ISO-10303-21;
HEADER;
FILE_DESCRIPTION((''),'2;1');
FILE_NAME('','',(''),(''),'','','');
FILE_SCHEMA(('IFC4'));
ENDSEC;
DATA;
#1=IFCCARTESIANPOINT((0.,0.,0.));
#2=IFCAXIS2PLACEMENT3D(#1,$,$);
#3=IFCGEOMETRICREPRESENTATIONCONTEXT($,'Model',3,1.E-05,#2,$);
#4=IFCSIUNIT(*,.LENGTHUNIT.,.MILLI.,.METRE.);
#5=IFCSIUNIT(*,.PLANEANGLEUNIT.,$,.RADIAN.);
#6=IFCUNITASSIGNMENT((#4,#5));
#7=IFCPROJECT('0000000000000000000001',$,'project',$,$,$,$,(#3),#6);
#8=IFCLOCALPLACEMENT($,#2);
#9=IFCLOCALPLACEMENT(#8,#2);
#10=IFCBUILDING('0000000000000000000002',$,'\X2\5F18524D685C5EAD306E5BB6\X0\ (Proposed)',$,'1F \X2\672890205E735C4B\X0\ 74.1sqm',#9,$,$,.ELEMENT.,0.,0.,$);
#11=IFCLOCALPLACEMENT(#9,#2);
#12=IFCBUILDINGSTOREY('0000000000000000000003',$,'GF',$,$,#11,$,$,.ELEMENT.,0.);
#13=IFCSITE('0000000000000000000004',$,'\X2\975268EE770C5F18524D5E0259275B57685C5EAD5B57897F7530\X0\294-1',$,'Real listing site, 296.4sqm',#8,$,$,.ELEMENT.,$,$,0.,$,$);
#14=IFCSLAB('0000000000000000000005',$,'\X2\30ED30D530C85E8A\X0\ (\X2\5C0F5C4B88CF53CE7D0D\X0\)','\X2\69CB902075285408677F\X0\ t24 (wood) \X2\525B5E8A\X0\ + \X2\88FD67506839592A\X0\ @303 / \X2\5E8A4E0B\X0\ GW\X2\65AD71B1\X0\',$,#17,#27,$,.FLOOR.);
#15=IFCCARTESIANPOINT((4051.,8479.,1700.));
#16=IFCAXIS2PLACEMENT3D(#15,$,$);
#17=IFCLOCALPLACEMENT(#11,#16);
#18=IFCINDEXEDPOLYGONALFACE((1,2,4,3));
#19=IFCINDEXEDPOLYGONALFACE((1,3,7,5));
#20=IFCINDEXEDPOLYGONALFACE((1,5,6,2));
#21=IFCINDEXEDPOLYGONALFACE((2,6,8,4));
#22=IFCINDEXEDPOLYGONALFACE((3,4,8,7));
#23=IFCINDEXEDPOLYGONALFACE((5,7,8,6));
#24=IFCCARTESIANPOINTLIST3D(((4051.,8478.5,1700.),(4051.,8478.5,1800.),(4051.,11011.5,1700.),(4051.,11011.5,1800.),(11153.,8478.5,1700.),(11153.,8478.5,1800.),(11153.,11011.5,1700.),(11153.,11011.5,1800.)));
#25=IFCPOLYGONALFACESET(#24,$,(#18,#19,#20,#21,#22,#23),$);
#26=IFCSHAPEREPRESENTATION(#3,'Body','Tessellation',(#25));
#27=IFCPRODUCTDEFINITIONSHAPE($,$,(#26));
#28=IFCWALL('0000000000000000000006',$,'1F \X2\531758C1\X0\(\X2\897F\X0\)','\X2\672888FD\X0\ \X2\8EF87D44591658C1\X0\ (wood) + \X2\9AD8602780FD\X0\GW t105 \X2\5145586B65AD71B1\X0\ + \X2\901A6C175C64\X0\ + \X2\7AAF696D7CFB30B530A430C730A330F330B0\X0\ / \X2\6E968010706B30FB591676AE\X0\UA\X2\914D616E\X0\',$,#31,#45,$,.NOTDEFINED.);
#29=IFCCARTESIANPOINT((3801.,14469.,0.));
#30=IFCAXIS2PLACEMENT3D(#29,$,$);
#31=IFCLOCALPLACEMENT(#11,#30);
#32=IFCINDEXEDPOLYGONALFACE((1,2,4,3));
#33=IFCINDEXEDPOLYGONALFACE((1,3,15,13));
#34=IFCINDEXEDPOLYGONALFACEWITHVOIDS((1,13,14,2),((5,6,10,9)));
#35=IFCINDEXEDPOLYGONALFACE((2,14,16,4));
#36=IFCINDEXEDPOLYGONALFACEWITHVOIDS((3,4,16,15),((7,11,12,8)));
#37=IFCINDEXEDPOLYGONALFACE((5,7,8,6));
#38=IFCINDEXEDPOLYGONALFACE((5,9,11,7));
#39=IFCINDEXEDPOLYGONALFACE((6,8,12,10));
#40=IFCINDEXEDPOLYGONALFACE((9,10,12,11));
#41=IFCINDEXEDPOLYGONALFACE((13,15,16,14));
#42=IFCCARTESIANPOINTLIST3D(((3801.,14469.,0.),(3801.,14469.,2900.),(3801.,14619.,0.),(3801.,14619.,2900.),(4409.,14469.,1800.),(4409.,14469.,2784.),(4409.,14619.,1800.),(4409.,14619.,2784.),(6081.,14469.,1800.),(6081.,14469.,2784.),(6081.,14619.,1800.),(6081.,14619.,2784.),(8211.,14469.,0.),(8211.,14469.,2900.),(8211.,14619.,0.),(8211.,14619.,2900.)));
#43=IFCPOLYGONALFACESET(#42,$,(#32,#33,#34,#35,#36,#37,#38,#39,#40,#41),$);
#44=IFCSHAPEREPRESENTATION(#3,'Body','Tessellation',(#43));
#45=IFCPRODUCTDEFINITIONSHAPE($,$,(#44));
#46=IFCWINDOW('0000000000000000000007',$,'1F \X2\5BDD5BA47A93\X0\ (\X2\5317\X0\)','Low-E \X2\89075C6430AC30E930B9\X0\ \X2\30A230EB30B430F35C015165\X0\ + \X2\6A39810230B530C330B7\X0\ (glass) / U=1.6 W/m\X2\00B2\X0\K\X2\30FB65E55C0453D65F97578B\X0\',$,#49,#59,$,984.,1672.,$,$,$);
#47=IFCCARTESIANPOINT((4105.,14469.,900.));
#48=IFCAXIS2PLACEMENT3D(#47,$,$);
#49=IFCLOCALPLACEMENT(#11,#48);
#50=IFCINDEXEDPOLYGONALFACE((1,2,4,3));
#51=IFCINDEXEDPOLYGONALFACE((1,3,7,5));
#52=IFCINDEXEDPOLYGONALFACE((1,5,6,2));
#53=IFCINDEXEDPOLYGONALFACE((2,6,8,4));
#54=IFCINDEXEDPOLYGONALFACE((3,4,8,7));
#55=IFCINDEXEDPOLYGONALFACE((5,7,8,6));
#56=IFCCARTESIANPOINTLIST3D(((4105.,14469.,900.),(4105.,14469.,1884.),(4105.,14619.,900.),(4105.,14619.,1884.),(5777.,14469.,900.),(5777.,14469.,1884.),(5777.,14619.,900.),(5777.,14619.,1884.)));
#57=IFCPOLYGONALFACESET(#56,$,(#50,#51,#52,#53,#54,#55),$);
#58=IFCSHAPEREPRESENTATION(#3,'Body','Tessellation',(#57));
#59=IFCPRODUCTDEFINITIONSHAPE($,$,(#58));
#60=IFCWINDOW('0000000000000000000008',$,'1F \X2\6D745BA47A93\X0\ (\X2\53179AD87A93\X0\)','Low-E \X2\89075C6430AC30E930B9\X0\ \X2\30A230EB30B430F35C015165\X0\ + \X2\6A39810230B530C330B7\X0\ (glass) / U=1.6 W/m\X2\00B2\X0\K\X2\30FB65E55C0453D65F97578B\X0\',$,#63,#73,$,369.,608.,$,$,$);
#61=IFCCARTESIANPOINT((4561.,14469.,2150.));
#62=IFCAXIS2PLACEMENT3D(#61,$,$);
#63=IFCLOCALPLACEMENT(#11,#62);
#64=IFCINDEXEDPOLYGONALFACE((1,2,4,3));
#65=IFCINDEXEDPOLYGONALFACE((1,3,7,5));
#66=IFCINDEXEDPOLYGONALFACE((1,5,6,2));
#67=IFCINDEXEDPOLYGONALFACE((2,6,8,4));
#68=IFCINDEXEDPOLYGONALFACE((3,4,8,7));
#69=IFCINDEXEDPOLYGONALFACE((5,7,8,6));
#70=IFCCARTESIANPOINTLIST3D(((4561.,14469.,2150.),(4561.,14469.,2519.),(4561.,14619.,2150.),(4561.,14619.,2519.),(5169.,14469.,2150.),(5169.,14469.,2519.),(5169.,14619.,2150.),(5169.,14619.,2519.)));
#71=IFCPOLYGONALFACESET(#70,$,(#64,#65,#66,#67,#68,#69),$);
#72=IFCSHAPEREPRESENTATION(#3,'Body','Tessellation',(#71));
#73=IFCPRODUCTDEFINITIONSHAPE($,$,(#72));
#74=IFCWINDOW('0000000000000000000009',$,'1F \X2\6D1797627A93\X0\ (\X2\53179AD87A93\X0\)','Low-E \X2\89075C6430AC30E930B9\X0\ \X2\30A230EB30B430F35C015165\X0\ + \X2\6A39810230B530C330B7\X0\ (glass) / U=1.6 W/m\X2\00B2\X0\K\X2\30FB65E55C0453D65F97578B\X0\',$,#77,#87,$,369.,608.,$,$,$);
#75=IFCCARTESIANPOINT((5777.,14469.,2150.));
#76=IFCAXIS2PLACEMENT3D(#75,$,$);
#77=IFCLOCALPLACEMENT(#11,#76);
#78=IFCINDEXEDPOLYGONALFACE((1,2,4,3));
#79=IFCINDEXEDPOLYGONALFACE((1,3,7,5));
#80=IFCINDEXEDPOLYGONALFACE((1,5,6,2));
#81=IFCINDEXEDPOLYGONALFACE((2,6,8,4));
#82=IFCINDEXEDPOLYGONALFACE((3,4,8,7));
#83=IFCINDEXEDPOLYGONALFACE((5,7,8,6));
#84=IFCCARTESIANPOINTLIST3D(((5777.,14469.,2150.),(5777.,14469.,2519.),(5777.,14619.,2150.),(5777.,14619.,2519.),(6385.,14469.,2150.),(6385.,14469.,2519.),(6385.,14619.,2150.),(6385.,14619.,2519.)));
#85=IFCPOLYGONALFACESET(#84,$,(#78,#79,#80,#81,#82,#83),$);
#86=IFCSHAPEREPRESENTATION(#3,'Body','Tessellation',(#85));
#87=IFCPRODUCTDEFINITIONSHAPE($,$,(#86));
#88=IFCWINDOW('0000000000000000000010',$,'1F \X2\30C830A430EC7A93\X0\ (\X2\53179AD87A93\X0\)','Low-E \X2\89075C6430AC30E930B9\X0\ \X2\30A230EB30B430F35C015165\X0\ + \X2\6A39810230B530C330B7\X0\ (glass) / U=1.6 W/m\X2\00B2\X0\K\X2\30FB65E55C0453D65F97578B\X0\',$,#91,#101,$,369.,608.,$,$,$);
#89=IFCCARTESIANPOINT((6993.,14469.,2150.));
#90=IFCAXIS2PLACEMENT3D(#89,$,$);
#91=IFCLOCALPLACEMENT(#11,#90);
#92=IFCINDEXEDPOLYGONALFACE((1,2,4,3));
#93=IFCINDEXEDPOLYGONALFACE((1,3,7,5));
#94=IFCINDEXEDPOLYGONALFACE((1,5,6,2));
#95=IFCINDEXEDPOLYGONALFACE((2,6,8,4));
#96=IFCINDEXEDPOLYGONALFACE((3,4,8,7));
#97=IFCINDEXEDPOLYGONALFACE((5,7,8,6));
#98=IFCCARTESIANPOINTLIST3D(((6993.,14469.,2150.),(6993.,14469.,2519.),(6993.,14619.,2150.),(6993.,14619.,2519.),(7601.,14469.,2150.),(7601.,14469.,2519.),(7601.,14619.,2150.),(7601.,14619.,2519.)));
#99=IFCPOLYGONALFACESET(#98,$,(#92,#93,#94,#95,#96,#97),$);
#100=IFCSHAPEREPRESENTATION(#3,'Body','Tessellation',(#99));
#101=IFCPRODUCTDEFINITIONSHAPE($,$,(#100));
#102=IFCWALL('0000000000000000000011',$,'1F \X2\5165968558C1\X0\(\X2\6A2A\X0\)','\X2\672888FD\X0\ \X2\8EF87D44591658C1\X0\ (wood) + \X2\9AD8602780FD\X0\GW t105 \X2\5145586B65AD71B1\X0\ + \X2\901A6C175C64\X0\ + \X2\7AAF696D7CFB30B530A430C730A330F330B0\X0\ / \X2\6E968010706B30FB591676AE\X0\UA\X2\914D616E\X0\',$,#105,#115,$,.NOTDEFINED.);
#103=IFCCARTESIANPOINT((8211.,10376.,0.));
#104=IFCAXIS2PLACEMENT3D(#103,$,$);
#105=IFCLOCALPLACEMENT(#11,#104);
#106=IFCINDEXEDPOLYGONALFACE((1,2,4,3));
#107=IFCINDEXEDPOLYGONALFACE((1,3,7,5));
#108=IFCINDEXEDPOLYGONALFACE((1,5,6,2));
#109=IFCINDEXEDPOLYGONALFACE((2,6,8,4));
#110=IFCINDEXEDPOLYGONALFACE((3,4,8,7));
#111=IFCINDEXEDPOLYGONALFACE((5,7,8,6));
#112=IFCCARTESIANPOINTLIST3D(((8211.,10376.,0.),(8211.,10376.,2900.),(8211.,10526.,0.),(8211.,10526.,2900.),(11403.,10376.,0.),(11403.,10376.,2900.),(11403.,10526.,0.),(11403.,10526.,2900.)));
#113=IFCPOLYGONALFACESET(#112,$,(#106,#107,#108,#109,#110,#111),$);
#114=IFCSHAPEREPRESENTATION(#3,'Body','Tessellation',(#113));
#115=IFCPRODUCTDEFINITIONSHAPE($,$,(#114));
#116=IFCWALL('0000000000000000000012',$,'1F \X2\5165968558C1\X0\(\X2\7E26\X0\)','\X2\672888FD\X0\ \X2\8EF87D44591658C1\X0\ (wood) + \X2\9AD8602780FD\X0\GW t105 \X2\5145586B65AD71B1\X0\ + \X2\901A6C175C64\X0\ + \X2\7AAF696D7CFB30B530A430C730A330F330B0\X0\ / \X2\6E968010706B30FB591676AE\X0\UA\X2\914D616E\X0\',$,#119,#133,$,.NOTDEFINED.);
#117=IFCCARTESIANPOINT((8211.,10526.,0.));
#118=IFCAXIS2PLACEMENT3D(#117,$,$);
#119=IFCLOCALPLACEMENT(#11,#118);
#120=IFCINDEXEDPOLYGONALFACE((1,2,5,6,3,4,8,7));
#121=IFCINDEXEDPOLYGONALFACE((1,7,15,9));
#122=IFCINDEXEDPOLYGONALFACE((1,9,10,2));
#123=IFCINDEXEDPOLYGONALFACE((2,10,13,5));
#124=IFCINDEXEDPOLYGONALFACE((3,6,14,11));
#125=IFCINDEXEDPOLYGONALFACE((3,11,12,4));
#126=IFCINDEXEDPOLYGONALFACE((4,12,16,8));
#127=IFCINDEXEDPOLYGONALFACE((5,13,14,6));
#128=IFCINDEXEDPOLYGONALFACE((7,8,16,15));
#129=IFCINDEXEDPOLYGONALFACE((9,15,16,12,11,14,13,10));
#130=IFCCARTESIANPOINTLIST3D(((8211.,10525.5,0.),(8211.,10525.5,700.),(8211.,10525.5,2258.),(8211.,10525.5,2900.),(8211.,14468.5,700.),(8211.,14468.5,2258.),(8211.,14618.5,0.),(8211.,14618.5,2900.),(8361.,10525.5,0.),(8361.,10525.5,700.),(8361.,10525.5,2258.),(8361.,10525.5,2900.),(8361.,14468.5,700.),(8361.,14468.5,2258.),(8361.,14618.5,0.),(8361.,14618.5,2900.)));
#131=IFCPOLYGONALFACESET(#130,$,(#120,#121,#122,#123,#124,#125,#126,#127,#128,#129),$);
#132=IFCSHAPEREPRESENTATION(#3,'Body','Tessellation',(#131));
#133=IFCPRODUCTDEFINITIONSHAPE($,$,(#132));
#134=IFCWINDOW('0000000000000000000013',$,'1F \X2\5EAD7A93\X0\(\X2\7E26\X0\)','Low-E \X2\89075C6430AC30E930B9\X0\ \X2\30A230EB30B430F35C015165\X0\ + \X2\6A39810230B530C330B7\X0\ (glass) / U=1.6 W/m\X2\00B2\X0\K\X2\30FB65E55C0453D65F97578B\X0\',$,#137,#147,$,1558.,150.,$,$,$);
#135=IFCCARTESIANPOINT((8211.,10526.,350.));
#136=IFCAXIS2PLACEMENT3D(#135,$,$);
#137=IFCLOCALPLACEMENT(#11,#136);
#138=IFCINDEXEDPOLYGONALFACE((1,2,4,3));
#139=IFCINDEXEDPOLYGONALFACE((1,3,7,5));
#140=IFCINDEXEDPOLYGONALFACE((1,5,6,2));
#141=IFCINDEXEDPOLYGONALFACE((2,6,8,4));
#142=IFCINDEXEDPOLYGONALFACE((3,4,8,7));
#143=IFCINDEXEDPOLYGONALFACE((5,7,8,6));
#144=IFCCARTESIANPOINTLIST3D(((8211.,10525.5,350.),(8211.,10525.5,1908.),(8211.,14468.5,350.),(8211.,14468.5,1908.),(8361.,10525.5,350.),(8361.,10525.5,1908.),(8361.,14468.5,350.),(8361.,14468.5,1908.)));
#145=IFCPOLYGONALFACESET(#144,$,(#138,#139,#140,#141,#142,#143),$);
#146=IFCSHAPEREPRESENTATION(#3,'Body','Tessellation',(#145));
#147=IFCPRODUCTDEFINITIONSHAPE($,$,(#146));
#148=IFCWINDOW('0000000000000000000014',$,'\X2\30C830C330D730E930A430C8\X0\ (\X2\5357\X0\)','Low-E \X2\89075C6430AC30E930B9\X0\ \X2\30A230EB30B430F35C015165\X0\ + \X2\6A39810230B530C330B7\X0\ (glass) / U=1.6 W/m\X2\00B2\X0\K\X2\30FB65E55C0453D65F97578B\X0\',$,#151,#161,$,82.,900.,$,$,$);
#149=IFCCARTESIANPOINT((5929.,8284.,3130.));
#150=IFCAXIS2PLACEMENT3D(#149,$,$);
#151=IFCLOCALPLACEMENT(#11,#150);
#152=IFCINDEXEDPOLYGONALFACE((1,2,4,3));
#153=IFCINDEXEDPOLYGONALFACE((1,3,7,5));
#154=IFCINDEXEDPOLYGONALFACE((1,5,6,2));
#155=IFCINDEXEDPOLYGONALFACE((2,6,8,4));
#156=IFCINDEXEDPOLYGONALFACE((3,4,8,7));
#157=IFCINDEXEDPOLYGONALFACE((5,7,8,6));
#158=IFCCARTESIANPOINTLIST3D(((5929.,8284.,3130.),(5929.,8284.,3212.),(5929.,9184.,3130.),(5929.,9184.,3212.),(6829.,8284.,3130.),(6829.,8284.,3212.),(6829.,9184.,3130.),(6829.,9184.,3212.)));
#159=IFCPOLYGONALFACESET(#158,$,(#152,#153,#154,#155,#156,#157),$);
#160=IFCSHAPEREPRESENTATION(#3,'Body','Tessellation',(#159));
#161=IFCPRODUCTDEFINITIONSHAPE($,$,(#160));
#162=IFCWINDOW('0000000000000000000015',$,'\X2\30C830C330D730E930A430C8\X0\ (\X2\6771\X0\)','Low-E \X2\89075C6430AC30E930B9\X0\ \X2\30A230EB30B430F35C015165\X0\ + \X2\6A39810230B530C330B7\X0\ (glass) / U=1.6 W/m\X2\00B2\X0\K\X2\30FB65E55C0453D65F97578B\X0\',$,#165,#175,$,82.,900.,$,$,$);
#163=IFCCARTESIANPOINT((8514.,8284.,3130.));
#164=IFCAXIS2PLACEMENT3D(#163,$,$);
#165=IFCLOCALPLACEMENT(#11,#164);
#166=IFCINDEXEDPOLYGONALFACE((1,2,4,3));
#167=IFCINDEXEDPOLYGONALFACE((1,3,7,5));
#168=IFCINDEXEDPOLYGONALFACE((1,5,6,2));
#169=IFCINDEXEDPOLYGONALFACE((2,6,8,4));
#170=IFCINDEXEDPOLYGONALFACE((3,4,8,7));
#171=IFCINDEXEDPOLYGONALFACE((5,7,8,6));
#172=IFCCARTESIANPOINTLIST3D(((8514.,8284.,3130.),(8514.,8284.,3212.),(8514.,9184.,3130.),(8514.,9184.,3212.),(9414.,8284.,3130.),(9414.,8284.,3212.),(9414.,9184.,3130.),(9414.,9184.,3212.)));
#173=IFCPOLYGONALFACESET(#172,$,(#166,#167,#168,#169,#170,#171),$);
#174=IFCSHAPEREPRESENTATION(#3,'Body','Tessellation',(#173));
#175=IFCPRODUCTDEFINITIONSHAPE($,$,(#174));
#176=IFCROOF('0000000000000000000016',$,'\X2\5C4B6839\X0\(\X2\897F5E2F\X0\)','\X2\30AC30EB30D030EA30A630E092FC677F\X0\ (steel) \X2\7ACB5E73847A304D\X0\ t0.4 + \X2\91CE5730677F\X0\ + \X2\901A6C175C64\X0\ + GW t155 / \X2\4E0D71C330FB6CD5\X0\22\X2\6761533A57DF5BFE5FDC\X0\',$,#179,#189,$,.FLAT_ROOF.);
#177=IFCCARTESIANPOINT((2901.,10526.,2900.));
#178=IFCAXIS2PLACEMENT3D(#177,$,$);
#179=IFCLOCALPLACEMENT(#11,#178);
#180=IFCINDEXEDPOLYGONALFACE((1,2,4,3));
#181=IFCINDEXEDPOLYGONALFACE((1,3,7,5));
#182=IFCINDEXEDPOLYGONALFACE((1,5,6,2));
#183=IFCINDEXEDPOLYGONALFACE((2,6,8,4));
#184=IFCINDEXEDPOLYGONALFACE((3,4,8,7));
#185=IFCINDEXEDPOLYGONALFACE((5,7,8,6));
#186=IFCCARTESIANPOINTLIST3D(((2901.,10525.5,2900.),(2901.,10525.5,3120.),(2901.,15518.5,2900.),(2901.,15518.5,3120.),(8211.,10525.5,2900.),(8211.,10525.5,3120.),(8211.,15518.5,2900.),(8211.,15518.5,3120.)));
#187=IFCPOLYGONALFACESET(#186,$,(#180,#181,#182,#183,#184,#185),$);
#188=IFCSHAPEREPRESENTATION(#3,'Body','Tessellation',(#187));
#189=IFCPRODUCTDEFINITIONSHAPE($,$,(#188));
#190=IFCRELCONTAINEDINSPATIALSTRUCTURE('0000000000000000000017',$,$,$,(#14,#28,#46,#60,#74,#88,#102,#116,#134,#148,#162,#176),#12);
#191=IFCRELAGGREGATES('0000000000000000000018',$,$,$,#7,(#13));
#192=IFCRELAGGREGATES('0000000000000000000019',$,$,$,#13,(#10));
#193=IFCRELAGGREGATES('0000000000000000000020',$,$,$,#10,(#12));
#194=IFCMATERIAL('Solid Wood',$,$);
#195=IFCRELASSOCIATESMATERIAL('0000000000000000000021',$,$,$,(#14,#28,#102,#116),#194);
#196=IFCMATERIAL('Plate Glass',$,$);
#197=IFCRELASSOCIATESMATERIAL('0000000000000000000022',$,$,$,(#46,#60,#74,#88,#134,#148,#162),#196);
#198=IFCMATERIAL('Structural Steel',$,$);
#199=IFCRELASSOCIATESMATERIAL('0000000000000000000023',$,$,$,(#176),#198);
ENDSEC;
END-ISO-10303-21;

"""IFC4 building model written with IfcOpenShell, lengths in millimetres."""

from ifc_helpers import new_model, si_unit, frame, frame_2d, origin, place, context, project, spatial, rectangle, extrude, material, element, fill, save


model = new_model("IFC4")

# Units and contexts
model_context = context("Model", 3, precision=1e-05, world=origin())
ifc_project = project(units=[si_unit("LENGTHUNIT", "METRE", prefix="MILLI"), si_unit("PLANEANGLEUNIT", "RADIAN")], contexts=[model_context])

# Site, building, storey
site_placement = place(None, origin())
site = spatial("IfcSite", under=ifc_project, at=site_placement, Name="青森県弘前市大字桜庭字西田294-1", ObjectType="Real listing site, 296.4sqm", CompositionType="ELEMENT", RefElevation=0.0)
building_placement = place(site_placement, origin())
building = spatial("IfcBuilding", under=site, at=building_placement, Name="弘前桜庭の家 (Proposed)", ObjectType="1F 木造平屋 74.1sqm", CompositionType="ELEMENT", ElevationOfRefHeight=0.0, ElevationOfTerrain=0.0)
storey_placement = place(building_placement, origin())
storey = spatial("IfcBuildingStorey", under=building, at=storey_placement, Name="GF", CompositionType="ELEMENT", Elevation=0.0)

# Slab
ifc_material_1 = material(Name="Solid Wood")
slab_1_placement = place(storey_placement, frame((4051.0, 8479.0, 1700.0)))
element("IfcSlab", 1, at=slab_1_placement, inside=storey, material=ifc_material_1, Name="ロフト床 (小屋裏収納)", Description="構造用合板 t24 (wood) 剛床 + 製材根太 @303 / 床下 GW断熱", PredefinedType="FLOOR", context=model_context, shape_type="SweptSolid", body=[
    extrude(rectangle(XDim=7102.0, YDim=2533.0, at=frame_2d((3551.0, 1266.0))), frame((4051.0, 8479.0, 1700.0)), (0.0, 0.0, 1.0), 100.0),
])

# Wall, openings, windows
wall_1_placement = place(storey_placement, frame((3801.0, 14469.0, 0.0)))
wall_1 = element("IfcWall", 2, at=wall_1_placement, inside=storey, material=ifc_material_1, Name="1F 北壁(西)", Description="木製 軸組外壁 (wood) + 高性能GW t105 充填断熱 + 通気層 + 窯業系サイディング / 準耐火・外皮UA配慮", PredefinedType="NOTDEFINED", context=model_context, shape_type="SweptSolid", body=[
    extrude(rectangle(XDim=4410.0, YDim=150.0, at=frame_2d((2205.0, 75.0))), frame((3801.0, 14469.0, 0.0)), (0.0, 0.0, 1.0), 2900.0),
])
opening_1_placement = place(storey_placement, frame((4105.0, 14469.0, 900.0)))
opening_1 = element("IfcOpeningElement", 3, at=opening_1_placement, cuts=wall_1, PredefinedType="NOTDEFINED", context=model_context, shape_type="SweptSolid", body=[
    extrude(rectangle(XDim=1672.0, YDim=150.0, at=frame_2d((836.0, 75.0))), frame((4105.0, 14469.0, 900.0)), (0.0, 0.0, 1.0), 984.0),
])
opening_2_placement = place(storey_placement, frame((4561.0, 14469.0, 2150.0)))
opening_2 = element("IfcOpeningElement", 4, at=opening_2_placement, cuts=wall_1, PredefinedType="NOTDEFINED", context=model_context, shape_type="SweptSolid", body=[
    extrude(rectangle(XDim=608.0, YDim=150.0, at=frame_2d((304.0, 75.0))), frame((4561.0, 14469.0, 2150.0)), (0.0, 0.0, 1.0), 369.0),
])
opening_3_placement = place(storey_placement, frame((5777.0, 14469.0, 2150.0)))
opening_3 = element("IfcOpeningElement", 5, at=opening_3_placement, cuts=wall_1, PredefinedType="NOTDEFINED", context=model_context, shape_type="SweptSolid", body=[
    extrude(rectangle(XDim=608.0, YDim=150.0, at=frame_2d((304.0, 75.0))), frame((5777.0, 14469.0, 2150.0)), (0.0, 0.0, 1.0), 369.0),
])
opening_4_placement = place(storey_placement, frame((6993.0, 14469.0, 2150.0)))
opening_4 = element("IfcOpeningElement", 6, at=opening_4_placement, cuts=wall_1, PredefinedType="NOTDEFINED", context=model_context, shape_type="SweptSolid", body=[
    extrude(rectangle(XDim=608.0, YDim=150.0, at=frame_2d((304.0, 75.0))), frame((6993.0, 14469.0, 2150.0)), (0.0, 0.0, 1.0), 369.0),
])
ifc_material_2 = material(Name="Plate Glass")
window_1_placement = place(storey_placement, frame((4105.0, 14469.0, 900.0)))
window_1 = element("IfcWindow", 7, at=window_1_placement, inside=storey, material=ifc_material_2, Name="1F 寝室窓 (北)", Description="Low-E 複層ガラス アルゴン封入 + 樹脂サッシ (glass) / U=1.6 W/m²K・日射取得型", OverallHeight=984.0, OverallWidth=1672.0, context=model_context, shape_type="SweptSolid", body=[
    extrude(rectangle(XDim=1672.0, YDim=150.0, at=frame_2d((836.0, 75.0))), frame((4105.0, 14469.0, 900.0)), (0.0, 0.0, 1.0), 984.0),
])
fill(opening_1, window_1)
window_2_placement = place(storey_placement, frame((4561.0, 14469.0, 2150.0)))
window_2 = element("IfcWindow", 8, at=window_2_placement, inside=storey, material=ifc_material_2, Name="1F 浴室窓 (北高窓)", Description="Low-E 複層ガラス アルゴン封入 + 樹脂サッシ (glass) / U=1.6 W/m²K・日射取得型", OverallHeight=369.0, OverallWidth=608.0, context=model_context, shape_type="SweptSolid", body=[
    extrude(rectangle(XDim=608.0, YDim=150.0, at=frame_2d((304.0, 75.0))), frame((4561.0, 14469.0, 2150.0)), (0.0, 0.0, 1.0), 369.0),
])
fill(opening_2, window_2)
window_3_placement = place(storey_placement, frame((5777.0, 14469.0, 2150.0)))
window_3 = element("IfcWindow", 9, at=window_3_placement, inside=storey, material=ifc_material_2, Name="1F 洗面窓 (北高窓)", Description="Low-E 複層ガラス アルゴン封入 + 樹脂サッシ (glass) / U=1.6 W/m²K・日射取得型", OverallHeight=369.0, OverallWidth=608.0, context=model_context, shape_type="SweptSolid", body=[
    extrude(rectangle(XDim=608.0, YDim=150.0, at=frame_2d((304.0, 75.0))), frame((5777.0, 14469.0, 2150.0)), (0.0, 0.0, 1.0), 369.0),
])
fill(opening_3, window_3)
window_4_placement = place(storey_placement, frame((6993.0, 14469.0, 2150.0)))
window_4 = element("IfcWindow", 10, at=window_4_placement, inside=storey, material=ifc_material_2, Name="1F トイレ窓 (北高窓)", Description="Low-E 複層ガラス アルゴン封入 + 樹脂サッシ (glass) / U=1.6 W/m²K・日射取得型", OverallHeight=369.0, OverallWidth=608.0, context=model_context, shape_type="SweptSolid", body=[
    extrude(rectangle(XDim=608.0, YDim=150.0, at=frame_2d((304.0, 75.0))), frame((6993.0, 14469.0, 2150.0)), (0.0, 0.0, 1.0), 369.0),
])
fill(opening_4, window_4)

# Wall
wall_2_placement = place(storey_placement, frame((8211.0, 10376.0, 0.0)))
element("IfcWall", 11, at=wall_2_placement, inside=storey, material=ifc_material_1, Name="1F 入隅壁(横)", Description="木製 軸組外壁 (wood) + 高性能GW t105 充填断熱 + 通気層 + 窯業系サイディング / 準耐火・外皮UA配慮", PredefinedType="NOTDEFINED", context=model_context, shape_type="SweptSolid", body=[
    extrude(rectangle(XDim=3192.0, YDim=150.0, at=frame_2d((1596.0, 75.0))), frame((8211.0, 10376.0, 0.0)), (0.0, 0.0, 1.0), 2900.0),
])

# Wall, opening, window
wall_3_placement = place(storey_placement, frame((8211.0, 10526.0, 0.0)))
wall_3 = element("IfcWall", 12, at=wall_3_placement, inside=storey, material=ifc_material_1, Name="1F 入隅壁(縦)", Description="木製 軸組外壁 (wood) + 高性能GW t105 充填断熱 + 通気層 + 窯業系サイディング / 準耐火・外皮UA配慮", PredefinedType="NOTDEFINED", context=model_context, shape_type="SweptSolid", body=[
    extrude(rectangle(XDim=150.0, YDim=4093.0, at=frame_2d((75.0, 2046.0))), frame((8211.0, 10526.0, 0.0)), (0.0, 0.0, 1.0), 2900.0),
])
opening_5_placement = place(storey_placement, frame((8211.0, 10526.0, 350.0)))
opening_5 = element("IfcOpeningElement", 13, at=opening_5_placement, cuts=wall_3, PredefinedType="NOTDEFINED", context=model_context, shape_type="SweptSolid", body=[
    extrude(rectangle(XDim=150.0, YDim=3943.0, at=frame_2d((75.0, 1971.0))), frame((8211.0, 10526.0, 350.0)), (0.0, 0.0, 1.0), 1558.0),
])
window_5_placement = place(storey_placement, frame((8211.0, 10526.0, 350.0)))
window_5 = element("IfcWindow", 14, at=window_5_placement, inside=storey, material=ifc_material_2, Name="1F 庭窓(縦)", Description="Low-E 複層ガラス アルゴン封入 + 樹脂サッシ (glass) / U=1.6 W/m²K・日射取得型", OverallHeight=1558.0, OverallWidth=150.0, context=model_context, shape_type="SweptSolid", body=[
    extrude(rectangle(XDim=150.0, YDim=3943.0, at=frame_2d((75.0, 1971.0))), frame((8211.0, 10526.0, 350.0)), (0.0, 0.0, 1.0), 1558.0),
])
fill(opening_5, window_5)

# Windows
window_6_placement = place(storey_placement, frame((5929.0, 8284.0, 3130.0)))
element("IfcWindow", 15, at=window_6_placement, inside=storey, material=ifc_material_2, Name="トップライト (南)", Description="Low-E 複層ガラス アルゴン封入 + 樹脂サッシ (glass) / U=1.6 W/m²K・日射取得型", OverallHeight=82.0, OverallWidth=900.0, context=model_context, shape_type="SweptSolid", body=[
    extrude(rectangle(XDim=900.0, YDim=900.0, at=frame_2d((450.0, 450.0))), frame((5929.0, 8284.0, 3130.0)), (0.0, 0.0, 1.0), 82.0),
])
window_7_placement = place(storey_placement, frame((8514.0, 8284.0, 3130.0)))
element("IfcWindow", 16, at=window_7_placement, inside=storey, material=ifc_material_2, Name="トップライト (東)", Description="Low-E 複層ガラス アルゴン封入 + 樹脂サッシ (glass) / U=1.6 W/m²K・日射取得型", OverallHeight=82.0, OverallWidth=900.0, context=model_context, shape_type="SweptSolid", body=[
    extrude(rectangle(XDim=900.0, YDim=900.0, at=frame_2d((450.0, 450.0))), frame((8514.0, 8284.0, 3130.0)), (0.0, 0.0, 1.0), 82.0),
])

# Roof
ifc_material_3 = material(Name="Structural Steel")
roof_placement = place(storey_placement, frame((2901.0, 10526.0, 2900.0)))
element("IfcRoof", 17, at=roof_placement, inside=storey, material=ifc_material_3, Name="屋根(西帯)", Description="ガルバリウム鋼板 (steel) 立平葺き t0.4 + 野地板 + 通気層 + GW t155 / 不燃・法22条区域対応", PredefinedType="FLAT_ROOF", context=model_context, shape_type="SweptSolid", body=[
    extrude(rectangle(XDim=5310.0, YDim=4993.0, at=frame_2d((2655.0, 2496.0))), frame((2901.0, 10526.0, 2900.0)), (0.0, 0.0, 1.0), 220.0),
])

save(model, "model.ifc")
